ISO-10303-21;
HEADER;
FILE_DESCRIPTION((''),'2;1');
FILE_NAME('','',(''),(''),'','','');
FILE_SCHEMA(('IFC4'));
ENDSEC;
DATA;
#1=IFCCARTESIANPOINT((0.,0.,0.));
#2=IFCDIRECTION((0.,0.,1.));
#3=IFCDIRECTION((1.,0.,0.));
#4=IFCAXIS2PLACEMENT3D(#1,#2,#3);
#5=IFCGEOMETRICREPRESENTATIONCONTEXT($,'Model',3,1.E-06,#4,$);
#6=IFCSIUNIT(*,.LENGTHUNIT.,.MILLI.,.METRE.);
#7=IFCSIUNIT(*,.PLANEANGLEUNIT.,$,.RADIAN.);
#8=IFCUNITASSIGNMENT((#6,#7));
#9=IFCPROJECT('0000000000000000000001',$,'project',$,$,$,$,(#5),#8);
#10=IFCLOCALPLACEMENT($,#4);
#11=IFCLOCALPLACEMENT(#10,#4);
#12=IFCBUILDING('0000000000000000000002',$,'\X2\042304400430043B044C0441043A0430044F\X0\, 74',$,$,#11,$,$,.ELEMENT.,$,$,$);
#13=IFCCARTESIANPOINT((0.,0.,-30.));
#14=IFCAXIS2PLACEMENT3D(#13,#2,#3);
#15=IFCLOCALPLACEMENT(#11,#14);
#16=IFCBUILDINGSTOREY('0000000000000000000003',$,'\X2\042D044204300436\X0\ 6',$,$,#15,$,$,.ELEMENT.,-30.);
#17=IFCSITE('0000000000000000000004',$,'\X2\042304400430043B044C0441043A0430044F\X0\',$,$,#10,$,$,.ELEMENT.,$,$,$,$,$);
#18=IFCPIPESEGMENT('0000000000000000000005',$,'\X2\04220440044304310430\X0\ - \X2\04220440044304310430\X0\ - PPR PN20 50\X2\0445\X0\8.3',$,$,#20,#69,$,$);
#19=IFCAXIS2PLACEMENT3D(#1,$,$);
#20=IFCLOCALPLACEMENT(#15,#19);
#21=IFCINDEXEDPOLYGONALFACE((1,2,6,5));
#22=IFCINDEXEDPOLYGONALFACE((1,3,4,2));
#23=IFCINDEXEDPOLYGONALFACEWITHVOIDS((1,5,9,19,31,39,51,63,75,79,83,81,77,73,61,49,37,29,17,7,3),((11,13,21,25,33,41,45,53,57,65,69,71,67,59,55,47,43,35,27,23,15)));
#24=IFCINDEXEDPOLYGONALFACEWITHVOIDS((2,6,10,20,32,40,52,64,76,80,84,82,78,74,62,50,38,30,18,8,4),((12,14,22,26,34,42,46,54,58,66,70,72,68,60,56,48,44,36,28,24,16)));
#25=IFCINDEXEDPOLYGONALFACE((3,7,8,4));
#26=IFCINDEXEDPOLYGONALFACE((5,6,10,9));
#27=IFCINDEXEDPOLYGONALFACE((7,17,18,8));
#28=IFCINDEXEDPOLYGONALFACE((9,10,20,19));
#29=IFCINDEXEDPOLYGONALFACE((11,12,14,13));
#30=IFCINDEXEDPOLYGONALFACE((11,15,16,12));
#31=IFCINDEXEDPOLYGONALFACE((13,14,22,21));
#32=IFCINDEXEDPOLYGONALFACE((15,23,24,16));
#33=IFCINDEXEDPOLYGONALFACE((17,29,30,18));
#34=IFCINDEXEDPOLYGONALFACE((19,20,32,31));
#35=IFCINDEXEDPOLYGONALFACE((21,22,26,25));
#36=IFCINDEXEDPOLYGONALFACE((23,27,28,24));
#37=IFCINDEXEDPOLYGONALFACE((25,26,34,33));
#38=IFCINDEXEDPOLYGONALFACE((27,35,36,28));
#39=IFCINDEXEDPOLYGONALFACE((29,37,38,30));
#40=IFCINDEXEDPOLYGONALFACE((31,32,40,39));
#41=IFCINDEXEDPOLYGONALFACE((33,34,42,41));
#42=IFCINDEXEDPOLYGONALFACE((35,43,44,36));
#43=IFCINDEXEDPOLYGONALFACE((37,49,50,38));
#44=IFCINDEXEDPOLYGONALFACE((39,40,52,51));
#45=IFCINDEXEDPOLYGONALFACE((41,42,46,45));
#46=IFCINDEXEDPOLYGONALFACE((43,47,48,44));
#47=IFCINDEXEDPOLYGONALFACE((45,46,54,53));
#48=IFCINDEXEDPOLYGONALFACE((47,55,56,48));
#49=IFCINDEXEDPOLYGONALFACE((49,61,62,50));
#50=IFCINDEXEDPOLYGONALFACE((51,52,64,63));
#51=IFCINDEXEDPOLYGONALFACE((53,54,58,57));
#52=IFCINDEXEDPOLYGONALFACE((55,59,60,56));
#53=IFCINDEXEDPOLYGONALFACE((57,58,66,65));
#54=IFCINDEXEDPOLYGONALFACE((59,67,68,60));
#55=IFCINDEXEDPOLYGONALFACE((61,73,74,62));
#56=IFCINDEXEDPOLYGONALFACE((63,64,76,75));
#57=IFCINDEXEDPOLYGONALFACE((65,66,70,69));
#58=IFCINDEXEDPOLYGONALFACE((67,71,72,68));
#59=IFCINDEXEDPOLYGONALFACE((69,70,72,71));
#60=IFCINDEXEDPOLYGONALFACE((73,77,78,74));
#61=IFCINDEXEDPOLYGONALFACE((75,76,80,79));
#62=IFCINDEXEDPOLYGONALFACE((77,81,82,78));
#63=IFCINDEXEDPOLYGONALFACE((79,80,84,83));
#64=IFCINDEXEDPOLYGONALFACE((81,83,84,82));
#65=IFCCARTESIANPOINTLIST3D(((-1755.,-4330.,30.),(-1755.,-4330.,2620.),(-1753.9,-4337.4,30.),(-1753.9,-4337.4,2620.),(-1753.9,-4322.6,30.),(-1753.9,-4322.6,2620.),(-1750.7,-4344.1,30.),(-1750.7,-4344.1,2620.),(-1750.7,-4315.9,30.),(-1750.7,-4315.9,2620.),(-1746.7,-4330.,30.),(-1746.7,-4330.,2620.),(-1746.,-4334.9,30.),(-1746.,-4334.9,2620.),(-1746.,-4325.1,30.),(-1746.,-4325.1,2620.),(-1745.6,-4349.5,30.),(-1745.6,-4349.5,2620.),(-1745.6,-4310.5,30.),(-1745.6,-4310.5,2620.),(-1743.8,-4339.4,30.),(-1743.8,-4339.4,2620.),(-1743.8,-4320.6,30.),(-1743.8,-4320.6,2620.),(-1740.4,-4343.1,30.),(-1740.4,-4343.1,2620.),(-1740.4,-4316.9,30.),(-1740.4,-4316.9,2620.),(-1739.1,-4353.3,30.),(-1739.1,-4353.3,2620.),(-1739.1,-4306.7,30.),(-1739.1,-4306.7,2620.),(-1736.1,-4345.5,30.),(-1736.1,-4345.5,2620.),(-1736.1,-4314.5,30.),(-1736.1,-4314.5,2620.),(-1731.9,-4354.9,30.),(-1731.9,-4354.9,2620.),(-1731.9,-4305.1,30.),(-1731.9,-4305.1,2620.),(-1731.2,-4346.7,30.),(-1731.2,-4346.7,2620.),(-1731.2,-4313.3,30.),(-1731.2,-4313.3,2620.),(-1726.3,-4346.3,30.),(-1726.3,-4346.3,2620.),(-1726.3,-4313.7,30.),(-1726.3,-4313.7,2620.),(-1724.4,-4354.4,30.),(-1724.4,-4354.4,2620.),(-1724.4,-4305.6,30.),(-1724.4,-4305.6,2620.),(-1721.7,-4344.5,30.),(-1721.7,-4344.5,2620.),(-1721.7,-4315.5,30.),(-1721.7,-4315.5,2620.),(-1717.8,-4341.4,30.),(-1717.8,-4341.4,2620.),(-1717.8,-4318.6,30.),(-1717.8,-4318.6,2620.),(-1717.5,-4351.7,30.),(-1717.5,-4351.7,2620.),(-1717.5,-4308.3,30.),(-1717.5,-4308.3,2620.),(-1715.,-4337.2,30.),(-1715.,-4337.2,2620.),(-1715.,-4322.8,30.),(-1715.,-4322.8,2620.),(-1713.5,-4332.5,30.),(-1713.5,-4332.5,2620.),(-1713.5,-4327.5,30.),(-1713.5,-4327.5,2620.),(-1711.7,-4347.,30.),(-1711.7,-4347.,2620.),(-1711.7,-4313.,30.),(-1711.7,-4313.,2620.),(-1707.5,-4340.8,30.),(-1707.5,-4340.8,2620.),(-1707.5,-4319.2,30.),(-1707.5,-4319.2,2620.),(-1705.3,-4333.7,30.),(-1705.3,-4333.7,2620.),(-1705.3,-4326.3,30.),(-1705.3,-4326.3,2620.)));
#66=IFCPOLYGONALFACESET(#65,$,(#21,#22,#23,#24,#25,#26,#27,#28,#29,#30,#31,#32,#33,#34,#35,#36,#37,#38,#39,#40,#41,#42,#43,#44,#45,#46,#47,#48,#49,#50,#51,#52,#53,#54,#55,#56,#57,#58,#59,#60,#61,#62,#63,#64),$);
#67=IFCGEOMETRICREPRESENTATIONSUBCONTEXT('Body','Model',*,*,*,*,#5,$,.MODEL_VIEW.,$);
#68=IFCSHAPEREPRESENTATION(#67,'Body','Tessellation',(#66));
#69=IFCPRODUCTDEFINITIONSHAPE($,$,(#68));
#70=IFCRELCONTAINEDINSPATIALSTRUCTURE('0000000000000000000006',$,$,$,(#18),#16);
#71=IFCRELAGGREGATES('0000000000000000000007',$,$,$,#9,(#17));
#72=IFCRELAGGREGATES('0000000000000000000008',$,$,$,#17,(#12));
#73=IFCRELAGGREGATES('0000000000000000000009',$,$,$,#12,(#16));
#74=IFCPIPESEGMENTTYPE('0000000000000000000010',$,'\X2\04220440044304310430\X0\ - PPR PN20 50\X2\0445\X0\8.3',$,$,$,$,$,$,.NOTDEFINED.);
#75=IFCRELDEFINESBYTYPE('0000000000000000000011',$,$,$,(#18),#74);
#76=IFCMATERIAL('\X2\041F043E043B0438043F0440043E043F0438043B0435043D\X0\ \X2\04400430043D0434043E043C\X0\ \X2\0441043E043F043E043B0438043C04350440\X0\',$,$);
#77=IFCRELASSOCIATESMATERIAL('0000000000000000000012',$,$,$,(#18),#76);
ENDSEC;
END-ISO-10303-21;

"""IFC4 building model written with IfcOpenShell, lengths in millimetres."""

from ifc_helpers import new_model, entity, si_unit, frame, origin_with_axes, place, context, subcontext, project, spatial, material, type_object, element, save


model = new_model("IFC4")

# Units and contexts
model_context = context("Model", 3, precision=1e-06, world=origin_with_axes())
body_context = subcontext(model_context, "Body", "Model", "MODEL_VIEW")
ifc_project = project(units=[si_unit("LENGTHUNIT", "METRE", prefix="MILLI"), si_unit("PLANEANGLEUNIT", "RADIAN")], contexts=[model_context])

# Site, building, storey
site_placement = place(None, origin_with_axes())
site = spatial("IfcSite", under=ifc_project, at=site_placement, Name="Уральская", CompositionType="ELEMENT")
building_placement = place(site_placement, origin_with_axes())
building = spatial("IfcBuilding", under=site, at=building_placement, Name="Уральская, 74", CompositionType="ELEMENT")
storey_placement = place(building_placement, frame((0.0, 0.0, -30.0), z_axis=(0.0, 0.0, 1.0), x_axis=(1.0, 0.0, 0.0)))
storey = spatial("IfcBuildingStorey", under=building, at=storey_placement, Name="Этаж 6", CompositionType="ELEMENT", Elevation=-30.0)

# Pipe segment
ifc_material_1 = material(Name="Полипропилен рандом сополимер")
pipe_segment_type_1 = type_object("IfcPipeSegmentType", Name="Труба - PPR PN20 50х8.3", PredefinedType="NOTDEFINED")
pipe_segment_1_placement = place(storey_placement, frame((-1730.0, -4330.0, 2620.0), z_axis=(0.0, 0.0, 1.0), x_axis=(1.0, 0.0, 0.0)))
element("IfcPipeSegment", 1, at=pipe_segment_1_placement, inside=storey, type_object=pipe_segment_type_1, material=ifc_material_1, Name="Труба - Труба - PPR PN20 50х8.3", context=body_context, shape_type="AdvancedSweptSolid", body=[
    entity("IfcSweptDiskSolid", entity("IfcIndexedPolyCurve", entity("IfcCartesianPointList3D", [[0.0, 0.0, 0.0], [0.0, 0.0, -2590.0]]), [entity("IfcLineIndex", [1, 2])]), 25.0, 16.7),
])

save(model, "model.ifc")
